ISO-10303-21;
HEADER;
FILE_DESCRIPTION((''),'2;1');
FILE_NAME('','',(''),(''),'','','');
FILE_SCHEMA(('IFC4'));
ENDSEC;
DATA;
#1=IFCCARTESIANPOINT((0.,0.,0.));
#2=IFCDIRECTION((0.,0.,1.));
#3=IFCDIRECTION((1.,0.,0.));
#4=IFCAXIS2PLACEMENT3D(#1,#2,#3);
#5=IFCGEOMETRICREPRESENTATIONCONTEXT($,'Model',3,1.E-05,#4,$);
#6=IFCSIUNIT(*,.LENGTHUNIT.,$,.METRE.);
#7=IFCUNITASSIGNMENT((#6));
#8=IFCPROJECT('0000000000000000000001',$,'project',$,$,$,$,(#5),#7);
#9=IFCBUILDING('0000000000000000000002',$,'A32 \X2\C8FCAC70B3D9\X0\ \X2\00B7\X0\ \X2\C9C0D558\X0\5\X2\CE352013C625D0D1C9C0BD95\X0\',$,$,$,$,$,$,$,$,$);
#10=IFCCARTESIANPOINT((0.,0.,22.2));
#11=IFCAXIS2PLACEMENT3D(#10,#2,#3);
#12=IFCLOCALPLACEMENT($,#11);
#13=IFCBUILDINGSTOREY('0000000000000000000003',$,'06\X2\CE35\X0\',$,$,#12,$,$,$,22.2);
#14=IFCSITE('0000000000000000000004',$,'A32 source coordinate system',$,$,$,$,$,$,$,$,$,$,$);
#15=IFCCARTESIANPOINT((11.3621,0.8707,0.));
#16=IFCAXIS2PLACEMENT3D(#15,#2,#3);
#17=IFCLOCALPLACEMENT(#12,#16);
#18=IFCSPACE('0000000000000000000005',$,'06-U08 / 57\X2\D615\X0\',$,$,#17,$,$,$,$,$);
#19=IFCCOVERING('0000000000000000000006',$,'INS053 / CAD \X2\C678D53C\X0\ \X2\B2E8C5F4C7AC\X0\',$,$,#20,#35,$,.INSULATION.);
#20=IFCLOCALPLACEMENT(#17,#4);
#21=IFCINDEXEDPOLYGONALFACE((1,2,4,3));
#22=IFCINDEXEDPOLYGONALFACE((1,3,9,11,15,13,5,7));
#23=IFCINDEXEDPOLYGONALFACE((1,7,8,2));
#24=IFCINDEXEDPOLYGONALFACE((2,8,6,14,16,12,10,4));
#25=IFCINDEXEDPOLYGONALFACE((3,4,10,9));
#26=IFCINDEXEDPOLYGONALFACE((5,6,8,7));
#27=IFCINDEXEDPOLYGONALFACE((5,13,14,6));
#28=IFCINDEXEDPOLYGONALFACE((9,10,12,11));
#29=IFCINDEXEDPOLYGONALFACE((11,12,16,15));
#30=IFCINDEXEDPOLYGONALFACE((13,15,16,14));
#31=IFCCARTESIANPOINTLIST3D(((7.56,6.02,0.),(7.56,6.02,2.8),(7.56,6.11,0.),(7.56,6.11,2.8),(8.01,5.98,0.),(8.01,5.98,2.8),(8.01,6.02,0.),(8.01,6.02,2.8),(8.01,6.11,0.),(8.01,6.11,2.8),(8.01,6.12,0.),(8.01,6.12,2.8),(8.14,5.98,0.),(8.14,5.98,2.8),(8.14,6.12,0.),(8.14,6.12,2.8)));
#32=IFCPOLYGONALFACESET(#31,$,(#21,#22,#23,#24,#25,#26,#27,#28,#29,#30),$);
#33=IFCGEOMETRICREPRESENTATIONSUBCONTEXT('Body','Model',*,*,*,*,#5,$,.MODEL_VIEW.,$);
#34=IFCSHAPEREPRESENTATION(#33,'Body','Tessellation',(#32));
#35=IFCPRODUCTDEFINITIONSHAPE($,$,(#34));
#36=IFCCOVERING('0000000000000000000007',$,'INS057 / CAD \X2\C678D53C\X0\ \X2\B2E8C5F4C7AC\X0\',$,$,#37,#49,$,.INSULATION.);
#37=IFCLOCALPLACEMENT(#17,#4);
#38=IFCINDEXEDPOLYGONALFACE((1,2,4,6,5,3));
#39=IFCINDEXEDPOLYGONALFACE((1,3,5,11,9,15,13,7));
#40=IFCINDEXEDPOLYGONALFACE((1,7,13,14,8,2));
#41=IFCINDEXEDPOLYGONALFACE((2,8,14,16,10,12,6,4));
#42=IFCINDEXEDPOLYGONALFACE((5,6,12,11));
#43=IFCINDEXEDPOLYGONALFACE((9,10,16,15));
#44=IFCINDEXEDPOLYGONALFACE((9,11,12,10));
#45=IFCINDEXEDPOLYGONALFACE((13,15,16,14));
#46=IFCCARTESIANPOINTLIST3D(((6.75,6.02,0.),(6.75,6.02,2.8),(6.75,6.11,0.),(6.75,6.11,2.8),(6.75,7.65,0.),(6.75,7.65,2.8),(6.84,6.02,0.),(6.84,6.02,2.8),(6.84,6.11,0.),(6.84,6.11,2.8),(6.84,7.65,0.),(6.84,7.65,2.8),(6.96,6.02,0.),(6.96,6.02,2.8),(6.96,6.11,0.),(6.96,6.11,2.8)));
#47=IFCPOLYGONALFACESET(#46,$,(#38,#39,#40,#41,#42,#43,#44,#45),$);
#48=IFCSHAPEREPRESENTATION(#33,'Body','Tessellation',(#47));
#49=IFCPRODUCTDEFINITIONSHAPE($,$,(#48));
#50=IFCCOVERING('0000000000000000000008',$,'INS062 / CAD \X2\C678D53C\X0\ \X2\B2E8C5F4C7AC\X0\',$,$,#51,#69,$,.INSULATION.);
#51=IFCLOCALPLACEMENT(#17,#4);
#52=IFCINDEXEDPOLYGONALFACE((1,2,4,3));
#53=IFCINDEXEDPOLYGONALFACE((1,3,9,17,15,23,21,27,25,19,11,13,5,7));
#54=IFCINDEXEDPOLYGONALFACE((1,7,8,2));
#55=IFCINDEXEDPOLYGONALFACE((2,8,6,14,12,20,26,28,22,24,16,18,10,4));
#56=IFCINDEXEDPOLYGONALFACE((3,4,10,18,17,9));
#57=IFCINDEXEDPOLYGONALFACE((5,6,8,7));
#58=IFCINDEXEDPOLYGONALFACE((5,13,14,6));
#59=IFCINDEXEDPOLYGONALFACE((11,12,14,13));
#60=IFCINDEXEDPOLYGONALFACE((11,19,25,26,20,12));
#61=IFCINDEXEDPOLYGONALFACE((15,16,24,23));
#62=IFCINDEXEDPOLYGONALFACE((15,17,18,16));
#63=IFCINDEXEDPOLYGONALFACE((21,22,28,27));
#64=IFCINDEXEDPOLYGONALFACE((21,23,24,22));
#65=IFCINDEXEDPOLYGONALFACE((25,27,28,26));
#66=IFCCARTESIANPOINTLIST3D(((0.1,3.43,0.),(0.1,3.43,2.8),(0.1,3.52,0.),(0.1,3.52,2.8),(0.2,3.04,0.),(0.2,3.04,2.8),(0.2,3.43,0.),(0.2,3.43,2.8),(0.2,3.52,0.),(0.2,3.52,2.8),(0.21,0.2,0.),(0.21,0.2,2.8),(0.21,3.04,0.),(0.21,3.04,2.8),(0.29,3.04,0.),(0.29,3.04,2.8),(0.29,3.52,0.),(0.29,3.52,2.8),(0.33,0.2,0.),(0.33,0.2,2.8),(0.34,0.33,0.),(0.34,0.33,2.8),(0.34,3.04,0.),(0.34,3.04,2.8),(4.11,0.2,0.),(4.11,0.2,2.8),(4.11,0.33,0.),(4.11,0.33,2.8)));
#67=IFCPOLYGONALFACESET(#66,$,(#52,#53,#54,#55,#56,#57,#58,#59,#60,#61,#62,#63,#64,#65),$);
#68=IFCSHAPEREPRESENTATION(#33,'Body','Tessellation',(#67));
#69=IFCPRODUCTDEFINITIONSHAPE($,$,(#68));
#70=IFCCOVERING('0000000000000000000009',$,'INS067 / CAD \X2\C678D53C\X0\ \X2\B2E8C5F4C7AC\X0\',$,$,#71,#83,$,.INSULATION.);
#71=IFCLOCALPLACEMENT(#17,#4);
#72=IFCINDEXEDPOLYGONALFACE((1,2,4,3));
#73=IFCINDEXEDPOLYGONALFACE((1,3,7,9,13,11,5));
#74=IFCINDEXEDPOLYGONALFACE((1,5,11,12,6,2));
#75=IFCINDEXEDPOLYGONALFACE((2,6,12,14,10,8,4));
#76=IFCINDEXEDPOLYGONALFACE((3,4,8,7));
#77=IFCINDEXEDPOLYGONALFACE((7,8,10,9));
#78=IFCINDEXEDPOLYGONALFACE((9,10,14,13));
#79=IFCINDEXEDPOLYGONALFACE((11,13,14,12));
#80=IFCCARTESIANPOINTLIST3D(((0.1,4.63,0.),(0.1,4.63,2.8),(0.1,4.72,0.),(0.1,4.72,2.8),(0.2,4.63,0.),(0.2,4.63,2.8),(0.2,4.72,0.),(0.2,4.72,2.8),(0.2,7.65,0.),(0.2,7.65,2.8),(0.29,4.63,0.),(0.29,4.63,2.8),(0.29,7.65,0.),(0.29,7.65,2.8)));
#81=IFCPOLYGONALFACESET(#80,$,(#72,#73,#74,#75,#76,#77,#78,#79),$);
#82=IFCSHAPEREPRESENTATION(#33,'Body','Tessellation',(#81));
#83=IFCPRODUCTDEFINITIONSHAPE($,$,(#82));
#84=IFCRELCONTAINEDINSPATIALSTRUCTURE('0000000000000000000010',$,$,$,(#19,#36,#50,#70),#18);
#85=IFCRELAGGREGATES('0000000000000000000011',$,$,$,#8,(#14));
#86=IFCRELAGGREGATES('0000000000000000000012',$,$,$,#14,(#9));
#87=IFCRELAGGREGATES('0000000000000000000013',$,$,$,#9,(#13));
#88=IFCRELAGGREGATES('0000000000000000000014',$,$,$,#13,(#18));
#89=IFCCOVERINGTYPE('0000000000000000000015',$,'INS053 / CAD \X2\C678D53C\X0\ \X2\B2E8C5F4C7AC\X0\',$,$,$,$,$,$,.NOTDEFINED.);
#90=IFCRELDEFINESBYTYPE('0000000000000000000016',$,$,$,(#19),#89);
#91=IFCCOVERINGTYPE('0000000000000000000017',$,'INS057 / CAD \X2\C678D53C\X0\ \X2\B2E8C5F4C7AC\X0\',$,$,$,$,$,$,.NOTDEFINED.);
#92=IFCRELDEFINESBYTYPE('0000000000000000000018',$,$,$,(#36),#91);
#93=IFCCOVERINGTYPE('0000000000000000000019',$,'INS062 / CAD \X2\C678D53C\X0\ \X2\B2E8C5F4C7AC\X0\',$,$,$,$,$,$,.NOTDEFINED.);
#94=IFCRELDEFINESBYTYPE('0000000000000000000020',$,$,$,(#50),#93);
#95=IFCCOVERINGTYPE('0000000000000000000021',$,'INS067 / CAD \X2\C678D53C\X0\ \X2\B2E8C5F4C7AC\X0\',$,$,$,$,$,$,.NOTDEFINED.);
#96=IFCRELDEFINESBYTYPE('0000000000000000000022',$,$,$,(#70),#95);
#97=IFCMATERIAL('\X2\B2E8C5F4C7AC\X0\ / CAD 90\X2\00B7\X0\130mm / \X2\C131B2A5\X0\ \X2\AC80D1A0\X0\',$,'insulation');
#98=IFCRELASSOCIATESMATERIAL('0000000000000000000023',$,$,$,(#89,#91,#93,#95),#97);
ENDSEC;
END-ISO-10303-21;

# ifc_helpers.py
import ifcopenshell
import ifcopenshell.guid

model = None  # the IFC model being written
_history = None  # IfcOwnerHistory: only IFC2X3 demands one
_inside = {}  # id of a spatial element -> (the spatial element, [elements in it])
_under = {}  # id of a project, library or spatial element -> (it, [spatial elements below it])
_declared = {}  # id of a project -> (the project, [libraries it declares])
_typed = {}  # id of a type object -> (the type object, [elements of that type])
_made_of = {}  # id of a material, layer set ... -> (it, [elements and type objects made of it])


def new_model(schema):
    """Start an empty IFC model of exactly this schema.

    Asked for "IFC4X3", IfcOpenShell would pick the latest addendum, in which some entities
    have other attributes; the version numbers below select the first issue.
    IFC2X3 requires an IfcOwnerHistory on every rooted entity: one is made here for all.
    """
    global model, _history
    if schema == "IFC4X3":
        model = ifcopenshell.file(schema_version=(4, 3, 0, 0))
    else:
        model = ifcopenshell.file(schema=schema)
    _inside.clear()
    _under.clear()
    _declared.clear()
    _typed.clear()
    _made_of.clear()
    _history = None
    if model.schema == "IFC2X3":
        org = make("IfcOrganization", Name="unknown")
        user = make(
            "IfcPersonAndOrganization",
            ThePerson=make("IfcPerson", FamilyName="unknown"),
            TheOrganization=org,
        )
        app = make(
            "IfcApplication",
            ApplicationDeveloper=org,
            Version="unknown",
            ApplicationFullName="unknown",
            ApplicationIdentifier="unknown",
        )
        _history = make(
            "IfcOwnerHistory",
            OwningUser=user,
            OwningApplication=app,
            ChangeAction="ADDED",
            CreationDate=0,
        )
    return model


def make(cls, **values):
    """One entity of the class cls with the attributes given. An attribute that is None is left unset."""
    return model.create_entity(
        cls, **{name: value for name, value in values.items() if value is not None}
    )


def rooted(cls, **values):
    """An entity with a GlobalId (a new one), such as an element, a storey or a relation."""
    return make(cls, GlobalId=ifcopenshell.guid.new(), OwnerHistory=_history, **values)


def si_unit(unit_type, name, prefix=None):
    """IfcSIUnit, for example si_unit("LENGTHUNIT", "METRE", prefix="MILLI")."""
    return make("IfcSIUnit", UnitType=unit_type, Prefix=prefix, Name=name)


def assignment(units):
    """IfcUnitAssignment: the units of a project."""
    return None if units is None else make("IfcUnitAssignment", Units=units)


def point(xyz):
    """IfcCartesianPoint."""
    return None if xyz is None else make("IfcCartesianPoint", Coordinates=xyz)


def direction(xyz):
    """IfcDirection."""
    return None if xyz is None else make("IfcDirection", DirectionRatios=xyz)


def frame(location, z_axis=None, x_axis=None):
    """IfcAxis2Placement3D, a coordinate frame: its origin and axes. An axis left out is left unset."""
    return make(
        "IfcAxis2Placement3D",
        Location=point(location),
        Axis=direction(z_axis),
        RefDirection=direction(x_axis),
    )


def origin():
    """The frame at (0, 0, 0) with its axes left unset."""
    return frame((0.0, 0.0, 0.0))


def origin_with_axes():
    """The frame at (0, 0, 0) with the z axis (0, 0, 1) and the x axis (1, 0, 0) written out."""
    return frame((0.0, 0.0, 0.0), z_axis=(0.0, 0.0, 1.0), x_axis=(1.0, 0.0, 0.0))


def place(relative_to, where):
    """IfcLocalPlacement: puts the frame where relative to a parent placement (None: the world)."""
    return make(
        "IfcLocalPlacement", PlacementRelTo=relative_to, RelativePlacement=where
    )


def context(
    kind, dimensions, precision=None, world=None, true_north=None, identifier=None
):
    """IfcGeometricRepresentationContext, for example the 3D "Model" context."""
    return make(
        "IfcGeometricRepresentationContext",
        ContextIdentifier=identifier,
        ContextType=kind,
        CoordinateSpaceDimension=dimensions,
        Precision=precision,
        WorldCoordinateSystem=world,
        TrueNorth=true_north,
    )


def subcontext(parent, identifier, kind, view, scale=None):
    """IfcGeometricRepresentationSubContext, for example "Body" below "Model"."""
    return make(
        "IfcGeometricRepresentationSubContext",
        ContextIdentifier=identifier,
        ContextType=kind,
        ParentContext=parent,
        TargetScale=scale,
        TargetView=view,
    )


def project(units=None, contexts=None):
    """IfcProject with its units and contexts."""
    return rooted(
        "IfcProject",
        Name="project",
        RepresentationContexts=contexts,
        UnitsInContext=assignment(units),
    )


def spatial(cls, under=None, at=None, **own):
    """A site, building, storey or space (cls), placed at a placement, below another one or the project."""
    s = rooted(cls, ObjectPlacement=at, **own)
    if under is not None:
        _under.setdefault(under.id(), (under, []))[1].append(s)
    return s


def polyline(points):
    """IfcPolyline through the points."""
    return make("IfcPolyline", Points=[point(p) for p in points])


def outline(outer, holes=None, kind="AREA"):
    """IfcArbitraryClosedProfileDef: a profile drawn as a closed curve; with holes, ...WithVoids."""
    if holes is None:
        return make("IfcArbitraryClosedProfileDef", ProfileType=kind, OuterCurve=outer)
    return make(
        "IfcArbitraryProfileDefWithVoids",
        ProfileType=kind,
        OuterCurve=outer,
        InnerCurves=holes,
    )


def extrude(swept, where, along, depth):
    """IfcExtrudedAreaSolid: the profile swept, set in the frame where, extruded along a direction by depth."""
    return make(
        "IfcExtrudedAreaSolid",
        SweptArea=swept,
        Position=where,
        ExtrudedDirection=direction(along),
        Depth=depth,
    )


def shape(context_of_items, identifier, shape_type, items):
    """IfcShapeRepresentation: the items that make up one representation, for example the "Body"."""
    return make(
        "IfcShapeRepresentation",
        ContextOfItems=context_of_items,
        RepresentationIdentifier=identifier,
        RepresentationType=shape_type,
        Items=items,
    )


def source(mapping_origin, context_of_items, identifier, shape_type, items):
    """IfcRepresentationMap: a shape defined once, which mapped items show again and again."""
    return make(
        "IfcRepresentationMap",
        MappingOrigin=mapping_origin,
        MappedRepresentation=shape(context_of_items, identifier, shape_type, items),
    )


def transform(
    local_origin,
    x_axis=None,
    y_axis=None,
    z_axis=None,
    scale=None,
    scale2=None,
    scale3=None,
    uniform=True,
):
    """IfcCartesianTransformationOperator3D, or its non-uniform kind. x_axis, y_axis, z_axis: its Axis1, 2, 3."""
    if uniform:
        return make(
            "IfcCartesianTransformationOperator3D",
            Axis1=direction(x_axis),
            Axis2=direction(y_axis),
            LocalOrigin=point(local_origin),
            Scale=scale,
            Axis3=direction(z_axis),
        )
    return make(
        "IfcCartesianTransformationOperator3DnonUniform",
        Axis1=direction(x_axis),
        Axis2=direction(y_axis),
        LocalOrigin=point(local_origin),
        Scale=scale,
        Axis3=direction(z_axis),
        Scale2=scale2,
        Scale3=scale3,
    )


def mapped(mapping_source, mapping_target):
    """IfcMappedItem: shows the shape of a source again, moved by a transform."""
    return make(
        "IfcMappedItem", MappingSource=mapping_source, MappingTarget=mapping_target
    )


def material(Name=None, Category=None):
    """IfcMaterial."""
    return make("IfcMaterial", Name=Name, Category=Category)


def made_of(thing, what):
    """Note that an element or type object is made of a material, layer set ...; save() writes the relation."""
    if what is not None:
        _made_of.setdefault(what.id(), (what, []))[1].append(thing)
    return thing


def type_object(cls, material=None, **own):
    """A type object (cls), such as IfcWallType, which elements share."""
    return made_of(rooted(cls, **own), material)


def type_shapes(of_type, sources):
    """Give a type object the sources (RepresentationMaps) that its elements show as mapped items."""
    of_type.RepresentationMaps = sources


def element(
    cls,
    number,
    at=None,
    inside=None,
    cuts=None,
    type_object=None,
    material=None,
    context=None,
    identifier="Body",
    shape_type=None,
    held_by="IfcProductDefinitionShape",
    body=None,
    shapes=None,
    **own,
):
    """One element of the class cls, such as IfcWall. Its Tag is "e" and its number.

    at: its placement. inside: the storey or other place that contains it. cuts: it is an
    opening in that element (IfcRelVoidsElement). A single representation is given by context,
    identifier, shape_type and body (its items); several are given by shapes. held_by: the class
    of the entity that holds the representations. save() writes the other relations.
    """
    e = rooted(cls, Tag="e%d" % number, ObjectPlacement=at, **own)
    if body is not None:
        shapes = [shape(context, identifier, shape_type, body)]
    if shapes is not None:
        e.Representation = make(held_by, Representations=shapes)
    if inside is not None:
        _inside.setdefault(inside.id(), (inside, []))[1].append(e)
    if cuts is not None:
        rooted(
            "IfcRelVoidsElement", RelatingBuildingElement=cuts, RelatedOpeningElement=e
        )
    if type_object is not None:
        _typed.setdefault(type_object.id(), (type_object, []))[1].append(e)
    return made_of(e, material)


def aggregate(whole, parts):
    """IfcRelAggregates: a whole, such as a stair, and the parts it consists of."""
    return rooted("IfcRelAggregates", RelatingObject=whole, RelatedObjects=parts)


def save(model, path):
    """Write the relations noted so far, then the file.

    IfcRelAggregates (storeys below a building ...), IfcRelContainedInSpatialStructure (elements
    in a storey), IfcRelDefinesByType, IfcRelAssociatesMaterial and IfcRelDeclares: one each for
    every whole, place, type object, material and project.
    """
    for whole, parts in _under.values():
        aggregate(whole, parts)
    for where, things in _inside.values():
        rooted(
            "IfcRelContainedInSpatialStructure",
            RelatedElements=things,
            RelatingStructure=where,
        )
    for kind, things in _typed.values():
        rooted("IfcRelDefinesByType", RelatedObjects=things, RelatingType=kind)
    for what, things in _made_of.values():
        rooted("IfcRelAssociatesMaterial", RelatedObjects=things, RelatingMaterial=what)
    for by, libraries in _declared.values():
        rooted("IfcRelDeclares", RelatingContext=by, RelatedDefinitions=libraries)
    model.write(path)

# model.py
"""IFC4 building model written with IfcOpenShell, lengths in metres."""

from ifc_helpers import new_model, si_unit, frame, origin, origin_with_axes, place, context, subcontext, project, spatial, polyline, outline, extrude, source, transform, mapped, material, type_object, type_shapes, element, save


model = new_model("IFC4")

# Units and contexts
model_context = context("Model", 3, precision=1e-05, world=origin_with_axes())
body_context = subcontext(model_context, "Body", "Model", "MODEL_VIEW")
ifc_project = project(units=[si_unit("LENGTHUNIT", "METRE")], contexts=[model_context])

# Site, building, storey, space
site = spatial("IfcSite", under=ifc_project, Name="A32 source coordinate system")
building = spatial("IfcBuilding", under=site, Name="A32 주거동 · 지하5층–옥탑지붕")
storey_placement = place(None, frame((0.0, 0.0, 22.2), z_axis=(0.0, 0.0, 1.0), x_axis=(1.0, 0.0, 0.0)))
storey = spatial("IfcBuildingStorey", under=building, at=storey_placement, Name="06층", Elevation=22.2)
space_1_placement = place(storey_placement, frame((11.3621, 0.8707, 0.0), z_axis=(0.0, 0.0, 1.0), x_axis=(1.0, 0.0, 0.0)))
space_1 = spatial("IfcSpace", under=storey, at=space_1_placement, Name="06-U08 / 57형")

# Coverings
ifc_material = material(Name="단열재 / CAD 90·130mm / 성능 검토", Category="insulation")
covering_type_1 = type_object("IfcCoveringType", Name="INS053 / CAD 외피 단열재", PredefinedType="NOTDEFINED", material=ifc_material)
shared_shape_1 = source(origin(), body_context, "Body", "SweptSolid", [
    extrude(outline(polyline([(8.01, 6.12), (8.14, 6.12), (8.14, 5.98), (8.01, 5.98), (8.01, 6.02), (7.56, 6.02), (7.56, 6.11), (8.01, 6.11), (8.01, 6.12)])), origin(), (0.0, 0.0, 1.0), 2.8),
])
type_shapes(covering_type_1, [shared_shape_1])
covering_1_placement = place(space_1_placement, origin_with_axes())
element("IfcCovering", 1, at=covering_1_placement, inside=space_1, type_object=covering_type_1, Name="INS053 / CAD 외피 단열재", PredefinedType="INSULATION", context=body_context, shape_type="MappedRepresentation", body=[
    mapped(shared_shape_1, transform((0.0, 0.0, 0.0), scale=1.0)),
])
covering_type_2 = type_object("IfcCoveringType", Name="INS057 / CAD 외피 단열재", PredefinedType="NOTDEFINED", material=ifc_material)
shared_shape_2 = source(origin(), body_context, "Body", "SweptSolid", [
    extrude(outline(polyline([(6.84, 6.11), (6.96, 6.11), (6.96, 6.02), (6.84, 6.02), (6.75, 6.02), (6.75, 6.11), (6.75, 7.65), (6.84, 7.65), (6.84, 6.11)])), origin(), (0.0, 0.0, 1.0), 2.8),
])
type_shapes(covering_type_2, [shared_shape_2])
covering_2_placement = place(space_1_placement, origin_with_axes())
element("IfcCovering", 2, at=covering_2_placement, inside=space_1, type_object=covering_type_2, Name="INS057 / CAD 외피 단열재", PredefinedType="INSULATION", context=body_context, shape_type="MappedRepresentation", body=[
    mapped(shared_shape_2, transform((0.0, 0.0, 0.0), scale=1.0)),
])
covering_type_3 = type_object("IfcCoveringType", Name="INS062 / CAD 외피 단열재", PredefinedType="NOTDEFINED", material=ifc_material)
shared_shape_3 = source(origin(), body_context, "Body", "SweptSolid", [
    extrude(outline(polyline([(4.11, 0.2), (0.33, 0.2), (0.21, 0.2), (0.21, 3.04), (0.2, 3.04), (0.2, 3.43), (0.1, 3.43), (0.1, 3.52), (0.2, 3.52), (0.29, 3.52), (0.29, 3.04), (0.34, 3.04), (0.34, 0.33), (4.11, 0.33), (4.11, 0.2)])), origin(), (0.0, 0.0, 1.0), 2.8),
])
type_shapes(covering_type_3, [shared_shape_3])
covering_3_placement = place(space_1_placement, origin_with_axes())
element("IfcCovering", 3, at=covering_3_placement, inside=space_1, type_object=covering_type_3, Name="INS062 / CAD 외피 단열재", PredefinedType="INSULATION", context=body_context, shape_type="MappedRepresentation", body=[
    mapped(shared_shape_3, transform((0.0, 0.0, 0.0), scale=1.0)),
])
covering_type_4 = type_object("IfcCoveringType", Name="INS067 / CAD 외피 단열재", PredefinedType="NOTDEFINED", material=ifc_material)
shared_shape_4 = source(origin(), body_context, "Body", "SweptSolid", [
    extrude(outline(polyline([(0.1, 4.72), (0.2, 4.72), (0.2, 7.65), (0.29, 7.65), (0.29, 4.63), (0.2, 4.63), (0.1, 4.63), (0.1, 4.72)])), origin(), (0.0, 0.0, 1.0), 2.8),
])
type_shapes(covering_type_4, [shared_shape_4])
covering_4_placement = place(space_1_placement, origin_with_axes())
element("IfcCovering", 4, at=covering_4_placement, inside=space_1, type_object=covering_type_4, Name="INS067 / CAD 외피 단열재", PredefinedType="INSULATION", context=body_context, shape_type="MappedRepresentation", body=[
    mapped(shared_shape_4, transform((0.0, 0.0, 0.0), scale=1.0)),
])

save(model, "model.ifc")
